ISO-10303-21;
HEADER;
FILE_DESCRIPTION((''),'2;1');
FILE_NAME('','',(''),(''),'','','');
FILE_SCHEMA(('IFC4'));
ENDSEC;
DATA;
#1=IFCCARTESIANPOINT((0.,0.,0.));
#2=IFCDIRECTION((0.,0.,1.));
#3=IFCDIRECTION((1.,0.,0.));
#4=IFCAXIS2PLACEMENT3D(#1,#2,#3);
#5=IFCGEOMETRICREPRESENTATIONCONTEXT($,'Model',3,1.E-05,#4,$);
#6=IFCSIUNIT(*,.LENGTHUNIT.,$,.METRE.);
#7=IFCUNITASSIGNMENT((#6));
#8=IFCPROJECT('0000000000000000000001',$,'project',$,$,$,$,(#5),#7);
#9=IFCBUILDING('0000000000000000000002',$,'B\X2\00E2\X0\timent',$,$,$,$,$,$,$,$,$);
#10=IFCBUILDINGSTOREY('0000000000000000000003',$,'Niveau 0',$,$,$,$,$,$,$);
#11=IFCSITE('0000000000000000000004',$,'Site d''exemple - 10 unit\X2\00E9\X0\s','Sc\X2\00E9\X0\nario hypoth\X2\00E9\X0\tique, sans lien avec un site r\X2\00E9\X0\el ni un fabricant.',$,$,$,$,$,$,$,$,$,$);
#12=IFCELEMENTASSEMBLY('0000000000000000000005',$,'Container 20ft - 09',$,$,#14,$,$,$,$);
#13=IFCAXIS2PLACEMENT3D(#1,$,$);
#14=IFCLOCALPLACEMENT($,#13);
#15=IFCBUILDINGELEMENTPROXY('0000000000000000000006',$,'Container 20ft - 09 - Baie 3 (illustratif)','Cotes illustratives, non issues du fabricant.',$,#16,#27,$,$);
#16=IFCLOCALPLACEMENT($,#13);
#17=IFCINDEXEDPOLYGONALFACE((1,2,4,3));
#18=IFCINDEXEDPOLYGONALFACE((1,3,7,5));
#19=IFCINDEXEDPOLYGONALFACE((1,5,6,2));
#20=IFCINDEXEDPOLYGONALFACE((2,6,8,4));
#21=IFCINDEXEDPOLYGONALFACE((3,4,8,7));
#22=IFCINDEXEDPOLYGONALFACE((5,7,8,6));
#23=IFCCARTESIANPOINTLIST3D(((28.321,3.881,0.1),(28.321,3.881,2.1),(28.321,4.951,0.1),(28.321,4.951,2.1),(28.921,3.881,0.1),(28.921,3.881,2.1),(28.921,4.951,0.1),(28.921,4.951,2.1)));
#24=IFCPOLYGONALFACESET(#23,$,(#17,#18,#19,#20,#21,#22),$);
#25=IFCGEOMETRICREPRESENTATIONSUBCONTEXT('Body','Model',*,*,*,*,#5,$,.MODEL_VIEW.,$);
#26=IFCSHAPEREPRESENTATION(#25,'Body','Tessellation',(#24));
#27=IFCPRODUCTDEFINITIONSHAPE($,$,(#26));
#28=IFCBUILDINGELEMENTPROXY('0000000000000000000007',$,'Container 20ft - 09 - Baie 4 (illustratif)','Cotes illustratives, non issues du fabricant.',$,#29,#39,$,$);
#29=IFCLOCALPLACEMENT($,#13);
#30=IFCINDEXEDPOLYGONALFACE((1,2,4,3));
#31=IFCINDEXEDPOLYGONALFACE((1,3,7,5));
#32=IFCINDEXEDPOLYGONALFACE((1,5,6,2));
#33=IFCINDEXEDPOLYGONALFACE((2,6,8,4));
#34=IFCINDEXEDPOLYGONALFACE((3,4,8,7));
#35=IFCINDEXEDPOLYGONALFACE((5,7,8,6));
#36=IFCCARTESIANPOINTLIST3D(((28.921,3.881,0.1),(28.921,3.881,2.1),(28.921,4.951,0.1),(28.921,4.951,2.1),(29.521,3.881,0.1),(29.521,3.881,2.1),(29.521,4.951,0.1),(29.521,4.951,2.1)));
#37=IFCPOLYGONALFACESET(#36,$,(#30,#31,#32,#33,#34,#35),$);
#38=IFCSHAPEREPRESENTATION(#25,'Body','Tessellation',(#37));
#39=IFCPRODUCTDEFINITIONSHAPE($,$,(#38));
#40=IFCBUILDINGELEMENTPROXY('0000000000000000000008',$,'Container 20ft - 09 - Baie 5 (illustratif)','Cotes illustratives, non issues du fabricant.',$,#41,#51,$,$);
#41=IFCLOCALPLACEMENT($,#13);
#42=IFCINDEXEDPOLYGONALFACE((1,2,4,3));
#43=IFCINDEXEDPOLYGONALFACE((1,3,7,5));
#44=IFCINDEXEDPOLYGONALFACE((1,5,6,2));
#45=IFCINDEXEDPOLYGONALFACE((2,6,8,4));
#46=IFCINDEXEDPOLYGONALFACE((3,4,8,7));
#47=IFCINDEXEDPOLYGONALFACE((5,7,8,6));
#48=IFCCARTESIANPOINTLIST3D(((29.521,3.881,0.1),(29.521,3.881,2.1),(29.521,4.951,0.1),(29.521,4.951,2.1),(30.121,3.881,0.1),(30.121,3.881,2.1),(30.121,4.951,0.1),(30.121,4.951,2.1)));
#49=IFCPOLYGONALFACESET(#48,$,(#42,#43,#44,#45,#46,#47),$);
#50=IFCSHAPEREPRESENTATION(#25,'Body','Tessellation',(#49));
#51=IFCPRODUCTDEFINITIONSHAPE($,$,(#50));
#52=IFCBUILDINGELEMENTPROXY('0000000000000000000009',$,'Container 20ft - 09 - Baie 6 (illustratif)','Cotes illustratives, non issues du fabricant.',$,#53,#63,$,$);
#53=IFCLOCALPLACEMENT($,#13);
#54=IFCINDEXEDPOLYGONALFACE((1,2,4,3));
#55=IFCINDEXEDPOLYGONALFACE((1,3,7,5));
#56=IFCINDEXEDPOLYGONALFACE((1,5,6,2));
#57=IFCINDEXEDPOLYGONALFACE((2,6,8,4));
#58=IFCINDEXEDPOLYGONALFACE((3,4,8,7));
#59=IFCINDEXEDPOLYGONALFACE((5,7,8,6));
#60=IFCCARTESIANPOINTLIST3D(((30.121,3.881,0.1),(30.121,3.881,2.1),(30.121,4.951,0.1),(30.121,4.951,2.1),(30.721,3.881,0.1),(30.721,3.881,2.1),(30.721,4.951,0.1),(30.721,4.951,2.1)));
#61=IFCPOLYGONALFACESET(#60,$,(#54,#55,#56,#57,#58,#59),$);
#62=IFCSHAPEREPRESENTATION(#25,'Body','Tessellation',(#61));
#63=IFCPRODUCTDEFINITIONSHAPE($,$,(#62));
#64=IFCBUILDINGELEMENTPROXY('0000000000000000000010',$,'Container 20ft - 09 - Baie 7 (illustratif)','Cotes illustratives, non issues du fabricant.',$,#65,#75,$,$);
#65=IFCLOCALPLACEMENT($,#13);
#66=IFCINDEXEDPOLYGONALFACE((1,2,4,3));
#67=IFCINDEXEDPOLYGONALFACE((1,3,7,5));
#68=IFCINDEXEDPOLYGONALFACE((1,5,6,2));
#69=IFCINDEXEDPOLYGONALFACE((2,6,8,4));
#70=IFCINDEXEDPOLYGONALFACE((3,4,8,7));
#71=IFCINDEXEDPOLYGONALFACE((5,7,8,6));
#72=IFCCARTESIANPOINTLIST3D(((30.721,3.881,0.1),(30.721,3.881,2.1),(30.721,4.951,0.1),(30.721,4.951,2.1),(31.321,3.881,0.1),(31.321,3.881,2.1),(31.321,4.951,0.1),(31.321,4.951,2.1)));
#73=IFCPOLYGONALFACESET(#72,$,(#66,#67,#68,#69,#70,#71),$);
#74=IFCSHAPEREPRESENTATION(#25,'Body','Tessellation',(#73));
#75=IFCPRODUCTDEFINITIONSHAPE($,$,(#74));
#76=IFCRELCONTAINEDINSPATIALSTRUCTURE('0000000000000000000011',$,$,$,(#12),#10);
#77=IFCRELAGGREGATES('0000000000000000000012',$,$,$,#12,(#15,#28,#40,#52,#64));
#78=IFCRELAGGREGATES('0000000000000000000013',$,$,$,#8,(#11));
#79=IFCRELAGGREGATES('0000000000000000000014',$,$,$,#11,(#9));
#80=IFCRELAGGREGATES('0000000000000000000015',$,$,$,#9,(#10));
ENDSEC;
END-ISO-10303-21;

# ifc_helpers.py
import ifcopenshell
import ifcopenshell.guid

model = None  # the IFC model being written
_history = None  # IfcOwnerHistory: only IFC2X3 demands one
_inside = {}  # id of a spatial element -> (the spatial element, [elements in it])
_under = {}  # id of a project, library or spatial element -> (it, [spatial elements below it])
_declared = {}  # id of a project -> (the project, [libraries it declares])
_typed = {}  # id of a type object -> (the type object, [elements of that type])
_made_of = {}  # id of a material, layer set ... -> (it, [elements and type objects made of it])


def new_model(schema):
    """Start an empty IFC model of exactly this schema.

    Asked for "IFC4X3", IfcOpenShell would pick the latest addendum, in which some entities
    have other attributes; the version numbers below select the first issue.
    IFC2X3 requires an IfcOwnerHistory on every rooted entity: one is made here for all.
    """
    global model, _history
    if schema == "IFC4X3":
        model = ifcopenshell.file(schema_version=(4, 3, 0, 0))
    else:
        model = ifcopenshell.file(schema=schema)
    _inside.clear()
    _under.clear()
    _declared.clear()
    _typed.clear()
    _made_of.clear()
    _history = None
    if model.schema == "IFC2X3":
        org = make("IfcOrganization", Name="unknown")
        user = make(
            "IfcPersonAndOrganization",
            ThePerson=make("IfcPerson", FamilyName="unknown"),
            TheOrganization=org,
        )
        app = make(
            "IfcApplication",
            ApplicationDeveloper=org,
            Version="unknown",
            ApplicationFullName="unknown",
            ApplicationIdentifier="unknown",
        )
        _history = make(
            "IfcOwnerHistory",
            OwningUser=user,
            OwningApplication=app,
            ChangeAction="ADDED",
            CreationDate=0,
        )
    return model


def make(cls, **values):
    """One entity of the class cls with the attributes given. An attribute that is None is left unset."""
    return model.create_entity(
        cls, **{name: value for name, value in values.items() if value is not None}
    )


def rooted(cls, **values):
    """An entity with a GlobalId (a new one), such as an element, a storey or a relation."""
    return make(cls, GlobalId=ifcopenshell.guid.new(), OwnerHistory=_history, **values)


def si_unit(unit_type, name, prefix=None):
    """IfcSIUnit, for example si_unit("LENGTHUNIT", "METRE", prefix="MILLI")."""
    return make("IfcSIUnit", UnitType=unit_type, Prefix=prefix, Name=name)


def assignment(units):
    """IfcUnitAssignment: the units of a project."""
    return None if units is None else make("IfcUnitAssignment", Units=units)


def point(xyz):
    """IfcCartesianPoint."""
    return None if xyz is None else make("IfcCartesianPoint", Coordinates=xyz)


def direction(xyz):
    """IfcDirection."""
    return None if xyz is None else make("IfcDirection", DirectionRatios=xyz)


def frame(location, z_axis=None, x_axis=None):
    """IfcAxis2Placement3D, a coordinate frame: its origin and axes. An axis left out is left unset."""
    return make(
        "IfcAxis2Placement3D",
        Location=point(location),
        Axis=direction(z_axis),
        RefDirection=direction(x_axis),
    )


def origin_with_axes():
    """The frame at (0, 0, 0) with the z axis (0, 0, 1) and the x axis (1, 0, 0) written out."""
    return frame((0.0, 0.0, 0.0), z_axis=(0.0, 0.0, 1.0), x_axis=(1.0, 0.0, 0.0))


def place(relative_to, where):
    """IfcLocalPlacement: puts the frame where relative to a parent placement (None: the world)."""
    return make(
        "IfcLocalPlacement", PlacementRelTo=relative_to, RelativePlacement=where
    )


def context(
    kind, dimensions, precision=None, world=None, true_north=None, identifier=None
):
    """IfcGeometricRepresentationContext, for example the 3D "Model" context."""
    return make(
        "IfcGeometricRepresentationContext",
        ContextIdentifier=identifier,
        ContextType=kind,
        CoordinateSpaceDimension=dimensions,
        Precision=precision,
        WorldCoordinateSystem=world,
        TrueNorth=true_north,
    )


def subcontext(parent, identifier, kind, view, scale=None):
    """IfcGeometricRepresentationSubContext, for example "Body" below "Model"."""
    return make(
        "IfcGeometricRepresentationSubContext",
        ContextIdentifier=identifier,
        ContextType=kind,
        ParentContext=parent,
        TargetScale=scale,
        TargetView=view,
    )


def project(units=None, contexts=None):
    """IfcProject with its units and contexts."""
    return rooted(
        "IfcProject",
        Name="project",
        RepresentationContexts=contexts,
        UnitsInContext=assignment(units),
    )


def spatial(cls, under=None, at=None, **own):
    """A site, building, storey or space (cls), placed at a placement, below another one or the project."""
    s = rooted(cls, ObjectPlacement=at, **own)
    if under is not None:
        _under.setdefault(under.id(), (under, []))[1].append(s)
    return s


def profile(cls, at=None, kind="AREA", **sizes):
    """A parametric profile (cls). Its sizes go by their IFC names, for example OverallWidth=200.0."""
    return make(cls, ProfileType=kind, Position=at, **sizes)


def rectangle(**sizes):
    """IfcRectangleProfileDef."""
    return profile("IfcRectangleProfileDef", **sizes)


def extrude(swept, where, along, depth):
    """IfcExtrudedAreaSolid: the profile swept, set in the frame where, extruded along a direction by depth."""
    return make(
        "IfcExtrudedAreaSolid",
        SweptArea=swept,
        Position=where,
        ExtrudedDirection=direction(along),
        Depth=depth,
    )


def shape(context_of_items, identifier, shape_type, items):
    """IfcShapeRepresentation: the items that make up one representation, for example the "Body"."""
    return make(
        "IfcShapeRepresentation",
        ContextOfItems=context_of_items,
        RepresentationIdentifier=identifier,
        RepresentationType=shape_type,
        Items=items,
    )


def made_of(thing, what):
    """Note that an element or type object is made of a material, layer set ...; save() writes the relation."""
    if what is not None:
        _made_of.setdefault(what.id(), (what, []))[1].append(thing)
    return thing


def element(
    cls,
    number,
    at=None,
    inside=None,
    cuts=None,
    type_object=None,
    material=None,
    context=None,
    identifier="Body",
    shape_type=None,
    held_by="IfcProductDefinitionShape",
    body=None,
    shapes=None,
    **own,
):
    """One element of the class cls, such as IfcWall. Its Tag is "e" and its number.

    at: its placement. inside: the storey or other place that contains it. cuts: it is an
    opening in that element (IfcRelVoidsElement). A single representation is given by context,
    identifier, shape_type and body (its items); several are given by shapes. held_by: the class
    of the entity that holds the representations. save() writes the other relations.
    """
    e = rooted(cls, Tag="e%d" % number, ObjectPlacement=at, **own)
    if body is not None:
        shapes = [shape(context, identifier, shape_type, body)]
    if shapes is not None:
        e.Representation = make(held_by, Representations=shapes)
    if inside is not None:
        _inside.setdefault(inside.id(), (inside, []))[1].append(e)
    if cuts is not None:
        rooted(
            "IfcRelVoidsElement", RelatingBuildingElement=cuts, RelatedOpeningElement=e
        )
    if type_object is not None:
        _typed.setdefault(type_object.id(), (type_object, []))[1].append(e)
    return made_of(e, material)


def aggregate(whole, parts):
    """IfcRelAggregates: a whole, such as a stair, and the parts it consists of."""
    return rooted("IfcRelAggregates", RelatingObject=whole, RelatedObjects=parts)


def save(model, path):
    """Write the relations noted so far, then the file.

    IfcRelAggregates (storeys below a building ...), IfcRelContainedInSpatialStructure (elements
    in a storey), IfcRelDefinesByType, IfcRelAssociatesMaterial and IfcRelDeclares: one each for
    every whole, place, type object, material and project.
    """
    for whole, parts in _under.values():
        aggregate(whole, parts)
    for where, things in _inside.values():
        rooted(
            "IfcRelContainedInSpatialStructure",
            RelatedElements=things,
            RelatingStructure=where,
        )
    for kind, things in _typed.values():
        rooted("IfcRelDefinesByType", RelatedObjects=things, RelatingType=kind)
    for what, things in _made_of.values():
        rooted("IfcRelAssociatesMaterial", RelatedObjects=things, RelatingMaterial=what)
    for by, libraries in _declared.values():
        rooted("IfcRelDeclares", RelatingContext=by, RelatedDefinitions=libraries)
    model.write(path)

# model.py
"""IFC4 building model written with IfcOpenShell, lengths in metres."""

from ifc_helpers import new_model, si_unit, frame, origin_with_axes, place, context, subcontext, project, spatial, rectangle, extrude, element, aggregate, save


model = new_model("IFC4")

# Units and contexts
model_context = context("Model", 3, precision=1e-05, world=origin_with_axes())
body_context = subcontext(model_context, "Body", "Model", "MODEL_VIEW")
ifc_project = project(units=[si_unit("LENGTHUNIT", "METRE")], contexts=[model_context])

# Site, building, storey
site = spatial("IfcSite", under=ifc_project, Name="Site d'exemple - 10 unités", Description="Scénario hypothétique, sans lien avec un site réel ni un fabricant.")
building = spatial("IfcBuilding", under=site, Name="Bâtiment")
storey = spatial("IfcBuildingStorey", under=building, Name="Niveau 0")

# Element assembly, building element proxies
assembly = element("IfcElementAssembly", 1, inside=storey, Name="Container 20ft - 09")
proxy_1_placement = place(None, frame((28.621, 4.416, 0.1), z_axis=(0.0, 0.0, 1.0), x_axis=(1.0, 0.0, 0.0)))
proxy_1 = element("IfcBuildingElementProxy", 2, at=proxy_1_placement, Name="Container 20ft - 09 - Baie 3 (illustratif)", Description="Cotes illustratives, non issues du fabricant.", context=body_context, shape_type="SweptSolid", body=[
    extrude(rectangle(XDim=0.6, YDim=1.07), origin_with_axes(), (0.0, 0.0, 1.0), 2.0),
])
proxy_2_placement = place(None, frame((29.221, 4.416, 0.1), z_axis=(0.0, 0.0, 1.0), x_axis=(1.0, 0.0, 0.0)))
proxy_2 = element("IfcBuildingElementProxy", 3, at=proxy_2_placement, Name="Container 20ft - 09 - Baie 4 (illustratif)", Description="Cotes illustratives, non issues du fabricant.", context=body_context, shape_type="SweptSolid", body=[
    extrude(rectangle(XDim=0.6, YDim=1.07), origin_with_axes(), (0.0, 0.0, 1.0), 2.0),
])
proxy_3_placement = place(None, frame((29.821, 4.416, 0.1), z_axis=(0.0, 0.0, 1.0), x_axis=(1.0, 0.0, 0.0)))
proxy_3 = element("IfcBuildingElementProxy", 4, at=proxy_3_placement, Name="Container 20ft - 09 - Baie 5 (illustratif)", Description="Cotes illustratives, non issues du fabricant.", context=body_context, shape_type="SweptSolid", body=[
    extrude(rectangle(XDim=0.6, YDim=1.07), origin_with_axes(), (0.0, 0.0, 1.0), 2.0),
])
proxy_4_placement = place(None, frame((30.421, 4.416, 0.1), z_axis=(0.0, 0.0, 1.0), x_axis=(1.0, 0.0, 0.0)))
proxy_4 = element("IfcBuildingElementProxy", 5, at=proxy_4_placement, Name="Container 20ft - 09 - Baie 6 (illustratif)", Description="Cotes illustratives, non issues du fabricant.", context=body_context, shape_type="SweptSolid", body=[
    extrude(rectangle(XDim=0.6, YDim=1.07), origin_with_axes(), (0.0, 0.0, 1.0), 2.0),
])
proxy_5_placement = place(None, frame((31.021, 4.416, 0.1), z_axis=(0.0, 0.0, 1.0), x_axis=(1.0, 0.0, 0.0)))
proxy_5 = element("IfcBuildingElementProxy", 6, at=proxy_5_placement, Name="Container 20ft - 09 - Baie 7 (illustratif)", Description="Cotes illustratives, non issues du fabricant.", context=body_context, shape_type="SweptSolid", body=[
    extrude(rectangle(XDim=0.6, YDim=1.07), origin_with_axes(), (0.0, 0.0, 1.0), 2.0),
])
aggregate(assembly, [proxy_1, proxy_2, proxy_3, proxy_4, proxy_5])

save(model, "model.ifc")
